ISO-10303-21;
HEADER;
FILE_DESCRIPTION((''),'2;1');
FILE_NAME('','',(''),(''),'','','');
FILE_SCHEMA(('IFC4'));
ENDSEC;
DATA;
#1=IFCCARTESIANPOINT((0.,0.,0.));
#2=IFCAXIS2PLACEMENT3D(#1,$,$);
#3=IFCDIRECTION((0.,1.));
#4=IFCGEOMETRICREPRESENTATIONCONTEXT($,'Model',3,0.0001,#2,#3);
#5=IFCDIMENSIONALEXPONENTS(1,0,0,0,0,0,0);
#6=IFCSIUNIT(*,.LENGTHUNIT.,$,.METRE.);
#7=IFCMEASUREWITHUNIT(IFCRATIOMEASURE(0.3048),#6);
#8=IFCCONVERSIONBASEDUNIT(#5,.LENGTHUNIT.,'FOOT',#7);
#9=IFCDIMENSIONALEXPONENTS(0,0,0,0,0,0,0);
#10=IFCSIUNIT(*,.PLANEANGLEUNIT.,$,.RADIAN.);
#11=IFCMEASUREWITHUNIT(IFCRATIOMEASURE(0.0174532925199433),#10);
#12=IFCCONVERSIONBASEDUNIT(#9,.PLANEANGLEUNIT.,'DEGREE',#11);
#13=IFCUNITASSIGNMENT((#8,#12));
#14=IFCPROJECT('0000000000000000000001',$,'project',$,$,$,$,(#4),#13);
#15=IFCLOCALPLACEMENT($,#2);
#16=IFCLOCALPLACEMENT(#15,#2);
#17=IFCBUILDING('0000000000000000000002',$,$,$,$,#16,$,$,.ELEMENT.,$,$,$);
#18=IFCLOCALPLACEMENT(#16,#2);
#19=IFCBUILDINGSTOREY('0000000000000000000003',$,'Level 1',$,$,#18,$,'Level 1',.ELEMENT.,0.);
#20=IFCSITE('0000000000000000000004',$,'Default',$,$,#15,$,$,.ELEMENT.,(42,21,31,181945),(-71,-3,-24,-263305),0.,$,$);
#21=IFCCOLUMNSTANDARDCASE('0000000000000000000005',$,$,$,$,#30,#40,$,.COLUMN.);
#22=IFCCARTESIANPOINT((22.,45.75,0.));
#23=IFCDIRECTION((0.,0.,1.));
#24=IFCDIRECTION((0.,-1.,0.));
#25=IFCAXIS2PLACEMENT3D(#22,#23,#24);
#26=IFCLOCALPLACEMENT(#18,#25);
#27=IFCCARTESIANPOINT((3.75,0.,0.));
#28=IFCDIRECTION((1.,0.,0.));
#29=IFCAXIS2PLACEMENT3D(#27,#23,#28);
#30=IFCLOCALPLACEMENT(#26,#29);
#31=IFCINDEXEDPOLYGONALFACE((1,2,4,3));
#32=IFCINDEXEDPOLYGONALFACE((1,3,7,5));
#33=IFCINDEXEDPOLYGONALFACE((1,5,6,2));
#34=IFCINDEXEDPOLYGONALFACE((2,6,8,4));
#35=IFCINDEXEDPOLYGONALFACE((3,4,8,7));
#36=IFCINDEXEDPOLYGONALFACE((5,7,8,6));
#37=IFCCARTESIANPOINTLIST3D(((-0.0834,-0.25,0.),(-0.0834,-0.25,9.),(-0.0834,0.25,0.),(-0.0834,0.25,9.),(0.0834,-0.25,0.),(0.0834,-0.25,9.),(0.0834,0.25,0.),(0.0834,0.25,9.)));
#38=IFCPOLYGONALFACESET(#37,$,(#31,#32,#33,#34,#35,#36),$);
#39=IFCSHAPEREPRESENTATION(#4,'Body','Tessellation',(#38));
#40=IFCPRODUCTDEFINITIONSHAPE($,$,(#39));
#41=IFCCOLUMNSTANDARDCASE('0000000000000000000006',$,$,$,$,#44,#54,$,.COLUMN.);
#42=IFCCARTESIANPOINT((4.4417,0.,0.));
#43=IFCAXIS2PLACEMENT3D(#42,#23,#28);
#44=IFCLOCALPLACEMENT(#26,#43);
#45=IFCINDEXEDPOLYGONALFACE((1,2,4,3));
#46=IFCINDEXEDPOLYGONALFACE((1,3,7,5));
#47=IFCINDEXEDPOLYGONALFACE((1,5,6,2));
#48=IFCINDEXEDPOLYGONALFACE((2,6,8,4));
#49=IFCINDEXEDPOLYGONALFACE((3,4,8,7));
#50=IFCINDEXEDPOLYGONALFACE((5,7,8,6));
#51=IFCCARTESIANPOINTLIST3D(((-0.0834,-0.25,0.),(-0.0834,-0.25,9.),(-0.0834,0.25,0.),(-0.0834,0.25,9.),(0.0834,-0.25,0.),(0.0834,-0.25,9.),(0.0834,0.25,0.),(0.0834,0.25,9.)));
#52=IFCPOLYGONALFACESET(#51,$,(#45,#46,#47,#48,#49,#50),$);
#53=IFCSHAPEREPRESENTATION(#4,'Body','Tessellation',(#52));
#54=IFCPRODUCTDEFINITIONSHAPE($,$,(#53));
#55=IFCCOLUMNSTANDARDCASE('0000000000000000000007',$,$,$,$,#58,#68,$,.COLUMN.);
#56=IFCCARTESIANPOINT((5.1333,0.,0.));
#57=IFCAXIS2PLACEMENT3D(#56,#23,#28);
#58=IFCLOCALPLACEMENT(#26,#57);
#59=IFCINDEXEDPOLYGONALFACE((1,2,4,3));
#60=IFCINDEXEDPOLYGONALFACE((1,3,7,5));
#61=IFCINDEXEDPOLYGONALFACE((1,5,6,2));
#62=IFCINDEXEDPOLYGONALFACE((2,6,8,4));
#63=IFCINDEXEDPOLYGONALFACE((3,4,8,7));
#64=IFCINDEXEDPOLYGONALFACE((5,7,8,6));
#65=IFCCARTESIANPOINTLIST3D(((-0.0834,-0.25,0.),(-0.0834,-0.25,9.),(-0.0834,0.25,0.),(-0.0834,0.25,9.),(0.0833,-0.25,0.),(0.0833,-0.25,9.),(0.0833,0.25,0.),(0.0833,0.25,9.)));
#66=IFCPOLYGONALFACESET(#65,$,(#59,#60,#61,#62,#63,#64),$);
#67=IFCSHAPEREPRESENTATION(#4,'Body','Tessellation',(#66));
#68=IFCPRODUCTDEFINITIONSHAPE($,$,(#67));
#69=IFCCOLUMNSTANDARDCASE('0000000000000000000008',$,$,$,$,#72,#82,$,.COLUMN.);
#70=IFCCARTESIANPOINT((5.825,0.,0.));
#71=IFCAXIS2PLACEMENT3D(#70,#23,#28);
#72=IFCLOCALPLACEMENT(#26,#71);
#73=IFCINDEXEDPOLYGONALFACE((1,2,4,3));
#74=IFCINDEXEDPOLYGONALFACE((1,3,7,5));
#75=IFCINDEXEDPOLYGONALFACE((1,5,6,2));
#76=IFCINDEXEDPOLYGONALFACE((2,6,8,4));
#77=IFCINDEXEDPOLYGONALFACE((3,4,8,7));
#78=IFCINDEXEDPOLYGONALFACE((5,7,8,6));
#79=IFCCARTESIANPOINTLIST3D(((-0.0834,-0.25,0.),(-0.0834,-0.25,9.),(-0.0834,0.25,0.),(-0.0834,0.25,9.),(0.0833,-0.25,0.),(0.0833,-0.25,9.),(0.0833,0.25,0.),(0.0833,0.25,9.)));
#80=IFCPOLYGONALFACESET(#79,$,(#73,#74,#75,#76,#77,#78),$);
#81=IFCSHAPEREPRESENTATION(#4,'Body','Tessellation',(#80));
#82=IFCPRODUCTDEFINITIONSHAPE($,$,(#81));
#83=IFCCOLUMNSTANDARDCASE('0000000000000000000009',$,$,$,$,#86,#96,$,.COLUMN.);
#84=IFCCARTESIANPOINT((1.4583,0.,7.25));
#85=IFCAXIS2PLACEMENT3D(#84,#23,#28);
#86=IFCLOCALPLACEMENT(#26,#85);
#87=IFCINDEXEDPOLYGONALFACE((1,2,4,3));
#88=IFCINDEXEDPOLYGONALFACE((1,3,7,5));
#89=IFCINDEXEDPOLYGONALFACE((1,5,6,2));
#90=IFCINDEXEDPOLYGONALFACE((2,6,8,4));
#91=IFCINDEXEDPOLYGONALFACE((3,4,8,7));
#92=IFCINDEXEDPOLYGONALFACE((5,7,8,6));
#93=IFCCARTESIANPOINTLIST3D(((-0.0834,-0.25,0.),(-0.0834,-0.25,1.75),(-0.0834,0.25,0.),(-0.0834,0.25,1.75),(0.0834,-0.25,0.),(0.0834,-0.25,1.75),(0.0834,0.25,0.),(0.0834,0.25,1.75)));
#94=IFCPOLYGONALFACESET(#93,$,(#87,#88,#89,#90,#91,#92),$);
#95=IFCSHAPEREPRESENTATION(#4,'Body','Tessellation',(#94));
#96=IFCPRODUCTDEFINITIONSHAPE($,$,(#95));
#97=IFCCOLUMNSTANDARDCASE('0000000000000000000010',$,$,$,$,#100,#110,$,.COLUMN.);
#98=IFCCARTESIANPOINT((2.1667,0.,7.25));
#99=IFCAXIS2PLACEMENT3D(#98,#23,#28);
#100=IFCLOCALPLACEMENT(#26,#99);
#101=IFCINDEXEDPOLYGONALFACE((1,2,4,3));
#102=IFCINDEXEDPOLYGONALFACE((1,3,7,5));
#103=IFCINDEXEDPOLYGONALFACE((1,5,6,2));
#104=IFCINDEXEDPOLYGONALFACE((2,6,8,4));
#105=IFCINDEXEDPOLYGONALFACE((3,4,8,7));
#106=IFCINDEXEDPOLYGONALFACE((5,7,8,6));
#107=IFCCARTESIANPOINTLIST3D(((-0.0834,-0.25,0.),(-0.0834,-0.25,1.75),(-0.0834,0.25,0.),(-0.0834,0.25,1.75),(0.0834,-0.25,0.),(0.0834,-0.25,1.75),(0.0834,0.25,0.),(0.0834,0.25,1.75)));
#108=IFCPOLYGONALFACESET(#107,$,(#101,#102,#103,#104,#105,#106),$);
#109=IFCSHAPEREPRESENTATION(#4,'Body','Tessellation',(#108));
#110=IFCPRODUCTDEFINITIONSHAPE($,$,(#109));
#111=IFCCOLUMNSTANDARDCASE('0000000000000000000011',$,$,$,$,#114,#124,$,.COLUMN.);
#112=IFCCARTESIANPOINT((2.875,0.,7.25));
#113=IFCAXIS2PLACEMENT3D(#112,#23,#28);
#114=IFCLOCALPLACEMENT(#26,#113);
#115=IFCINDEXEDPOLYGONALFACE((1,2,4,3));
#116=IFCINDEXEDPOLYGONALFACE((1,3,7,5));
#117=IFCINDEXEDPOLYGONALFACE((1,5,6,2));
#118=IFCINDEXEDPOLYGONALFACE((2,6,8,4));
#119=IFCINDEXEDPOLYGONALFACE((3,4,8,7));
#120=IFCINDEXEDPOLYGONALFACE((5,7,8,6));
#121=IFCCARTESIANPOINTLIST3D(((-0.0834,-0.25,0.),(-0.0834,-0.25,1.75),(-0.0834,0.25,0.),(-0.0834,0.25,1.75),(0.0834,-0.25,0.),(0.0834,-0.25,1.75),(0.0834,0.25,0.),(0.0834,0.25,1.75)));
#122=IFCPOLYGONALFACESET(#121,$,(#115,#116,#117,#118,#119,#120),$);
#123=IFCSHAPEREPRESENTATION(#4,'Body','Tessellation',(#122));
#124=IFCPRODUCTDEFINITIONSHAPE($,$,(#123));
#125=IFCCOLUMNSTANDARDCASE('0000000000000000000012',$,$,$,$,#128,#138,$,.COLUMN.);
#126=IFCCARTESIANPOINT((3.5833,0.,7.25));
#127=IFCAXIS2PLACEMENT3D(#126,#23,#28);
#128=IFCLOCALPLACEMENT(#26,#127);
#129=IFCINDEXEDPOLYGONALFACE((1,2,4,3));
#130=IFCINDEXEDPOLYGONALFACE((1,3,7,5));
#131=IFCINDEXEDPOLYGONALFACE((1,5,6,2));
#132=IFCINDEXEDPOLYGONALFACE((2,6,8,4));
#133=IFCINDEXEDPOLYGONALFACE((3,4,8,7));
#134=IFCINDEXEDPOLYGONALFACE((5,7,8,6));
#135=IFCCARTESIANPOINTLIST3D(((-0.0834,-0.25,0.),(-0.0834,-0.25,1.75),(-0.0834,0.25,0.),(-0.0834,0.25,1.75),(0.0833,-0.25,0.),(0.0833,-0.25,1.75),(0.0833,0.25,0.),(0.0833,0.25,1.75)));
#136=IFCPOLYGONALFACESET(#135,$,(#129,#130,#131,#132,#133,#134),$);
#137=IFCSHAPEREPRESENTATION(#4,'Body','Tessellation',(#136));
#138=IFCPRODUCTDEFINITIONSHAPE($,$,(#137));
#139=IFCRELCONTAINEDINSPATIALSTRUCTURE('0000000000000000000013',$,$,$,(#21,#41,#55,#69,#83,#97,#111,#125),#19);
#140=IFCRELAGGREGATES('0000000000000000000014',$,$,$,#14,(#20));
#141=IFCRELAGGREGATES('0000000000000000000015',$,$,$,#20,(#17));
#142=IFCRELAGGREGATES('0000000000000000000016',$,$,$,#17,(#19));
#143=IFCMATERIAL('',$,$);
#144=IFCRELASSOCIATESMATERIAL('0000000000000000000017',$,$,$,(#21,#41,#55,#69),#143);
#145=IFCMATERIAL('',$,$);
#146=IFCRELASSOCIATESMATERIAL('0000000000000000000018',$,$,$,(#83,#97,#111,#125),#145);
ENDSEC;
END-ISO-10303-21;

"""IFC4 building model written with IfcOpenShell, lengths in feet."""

from ifc_helpers import new_model, entity, si_unit, converted_unit, direction, frame, origin, place, context, project, spatial, rectangle, extrude, material, element, save


model = new_model("IFC4")

# Units and contexts
model_context = context("Model", 3, precision=0.0001, world=origin(), true_north=direction((0.0, 1.0)))
ifc_project = project(units=[converted_unit("LENGTHUNIT", "FOOT", entity("IfcRatioMeasure", 0.3048), si_unit("LENGTHUNIT", "METRE"), dimensions=[1, 0, 0, 0, 0, 0, 0]), converted_unit("PLANEANGLEUNIT", "DEGREE", entity("IfcRatioMeasure", 0.0174532925199433), si_unit("PLANEANGLEUNIT", "RADIAN"), dimensions=[0, 0, 0, 0, 0, 0, 0])], contexts=[model_context])

# Site, building, storey
site_placement = place(None, origin())
site = spatial("IfcSite", under=ifc_project, at=site_placement, Name="Default", CompositionType="ELEMENT", RefLatitude=(42, 21, 31, 181945), RefLongitude=(-71, -3, -24, -263305), RefElevation=0.0)
building_placement = place(site_placement, origin())
building = spatial("IfcBuilding", under=site, at=building_placement, CompositionType="ELEMENT")
storey_placement = place(building_placement, origin())
storey = spatial("IfcBuildingStorey", under=building, at=storey_placement, Name="Level 1", LongName="Level 1", CompositionType="ELEMENT", Elevation=0.0)

# Columns
ifc_material_1 = material(Name="")
ifc_material_2 = material(Name="")
placement_1 = place(storey_placement, frame((22.0, 45.75, 0.0), z_axis=(0.0, 0.0, 1.0), x_axis=(0.0, -1.0, 0.0)))
for number, where, z_axis, x_axis in (
    (1, (3.75, 0.0, 0.0), (0.0, 0.0, 1.0), (1.0, 0.0, 0.0)),
    (2, (4.4417, 0.0, 0.0), (0.0, 0.0, 1.0), (1.0, 0.0, 0.0)),
    (3, (5.1333, 0.0, 0.0), (0.0, 0.0, 1.0), (1.0, 0.0, 0.0)),
    (4, (5.825, 0.0, 0.0), (0.0, 0.0, 1.0), (1.0, 0.0, 0.0)),
):
    element("IfcColumnStandardCase", number, at=place(placement_1, frame(where, z_axis=z_axis, x_axis=x_axis)), inside=storey, material=ifc_material_1, PredefinedType="COLUMN", context=model_context, shape_type="SweptSolid", body=[
        extrude(rectangle(XDim=0.1667, YDim=0.5), origin(), (0.0, 0.0, 1.0), 9.0),
    ])
for number, where, z_axis, x_axis in (
    (5, (1.4583, 0.0, 7.25), (0.0, 0.0, 1.0), (1.0, 0.0, 0.0)),
    (6, (2.1667, 0.0, 7.25), (0.0, 0.0, 1.0), (1.0, 0.0, 0.0)),
    (7, (2.875, 0.0, 7.25), (0.0, 0.0, 1.0), (1.0, 0.0, 0.0)),
    (8, (3.5833, 0.0, 7.25), (0.0, 0.0, 1.0), (1.0, 0.0, 0.0)),
):
    element("IfcColumnStandardCase", number, at=place(placement_1, frame(where, z_axis=z_axis, x_axis=x_axis)), inside=storey, material=ifc_material_2, PredefinedType="COLUMN", context=model_context, shape_type="SweptSolid", body=[
        extrude(rectangle(XDim=0.1667, YDim=0.5), origin(), (0.0, 0.0, 1.0), 1.75),
    ])

save(model, "model.ifc")
